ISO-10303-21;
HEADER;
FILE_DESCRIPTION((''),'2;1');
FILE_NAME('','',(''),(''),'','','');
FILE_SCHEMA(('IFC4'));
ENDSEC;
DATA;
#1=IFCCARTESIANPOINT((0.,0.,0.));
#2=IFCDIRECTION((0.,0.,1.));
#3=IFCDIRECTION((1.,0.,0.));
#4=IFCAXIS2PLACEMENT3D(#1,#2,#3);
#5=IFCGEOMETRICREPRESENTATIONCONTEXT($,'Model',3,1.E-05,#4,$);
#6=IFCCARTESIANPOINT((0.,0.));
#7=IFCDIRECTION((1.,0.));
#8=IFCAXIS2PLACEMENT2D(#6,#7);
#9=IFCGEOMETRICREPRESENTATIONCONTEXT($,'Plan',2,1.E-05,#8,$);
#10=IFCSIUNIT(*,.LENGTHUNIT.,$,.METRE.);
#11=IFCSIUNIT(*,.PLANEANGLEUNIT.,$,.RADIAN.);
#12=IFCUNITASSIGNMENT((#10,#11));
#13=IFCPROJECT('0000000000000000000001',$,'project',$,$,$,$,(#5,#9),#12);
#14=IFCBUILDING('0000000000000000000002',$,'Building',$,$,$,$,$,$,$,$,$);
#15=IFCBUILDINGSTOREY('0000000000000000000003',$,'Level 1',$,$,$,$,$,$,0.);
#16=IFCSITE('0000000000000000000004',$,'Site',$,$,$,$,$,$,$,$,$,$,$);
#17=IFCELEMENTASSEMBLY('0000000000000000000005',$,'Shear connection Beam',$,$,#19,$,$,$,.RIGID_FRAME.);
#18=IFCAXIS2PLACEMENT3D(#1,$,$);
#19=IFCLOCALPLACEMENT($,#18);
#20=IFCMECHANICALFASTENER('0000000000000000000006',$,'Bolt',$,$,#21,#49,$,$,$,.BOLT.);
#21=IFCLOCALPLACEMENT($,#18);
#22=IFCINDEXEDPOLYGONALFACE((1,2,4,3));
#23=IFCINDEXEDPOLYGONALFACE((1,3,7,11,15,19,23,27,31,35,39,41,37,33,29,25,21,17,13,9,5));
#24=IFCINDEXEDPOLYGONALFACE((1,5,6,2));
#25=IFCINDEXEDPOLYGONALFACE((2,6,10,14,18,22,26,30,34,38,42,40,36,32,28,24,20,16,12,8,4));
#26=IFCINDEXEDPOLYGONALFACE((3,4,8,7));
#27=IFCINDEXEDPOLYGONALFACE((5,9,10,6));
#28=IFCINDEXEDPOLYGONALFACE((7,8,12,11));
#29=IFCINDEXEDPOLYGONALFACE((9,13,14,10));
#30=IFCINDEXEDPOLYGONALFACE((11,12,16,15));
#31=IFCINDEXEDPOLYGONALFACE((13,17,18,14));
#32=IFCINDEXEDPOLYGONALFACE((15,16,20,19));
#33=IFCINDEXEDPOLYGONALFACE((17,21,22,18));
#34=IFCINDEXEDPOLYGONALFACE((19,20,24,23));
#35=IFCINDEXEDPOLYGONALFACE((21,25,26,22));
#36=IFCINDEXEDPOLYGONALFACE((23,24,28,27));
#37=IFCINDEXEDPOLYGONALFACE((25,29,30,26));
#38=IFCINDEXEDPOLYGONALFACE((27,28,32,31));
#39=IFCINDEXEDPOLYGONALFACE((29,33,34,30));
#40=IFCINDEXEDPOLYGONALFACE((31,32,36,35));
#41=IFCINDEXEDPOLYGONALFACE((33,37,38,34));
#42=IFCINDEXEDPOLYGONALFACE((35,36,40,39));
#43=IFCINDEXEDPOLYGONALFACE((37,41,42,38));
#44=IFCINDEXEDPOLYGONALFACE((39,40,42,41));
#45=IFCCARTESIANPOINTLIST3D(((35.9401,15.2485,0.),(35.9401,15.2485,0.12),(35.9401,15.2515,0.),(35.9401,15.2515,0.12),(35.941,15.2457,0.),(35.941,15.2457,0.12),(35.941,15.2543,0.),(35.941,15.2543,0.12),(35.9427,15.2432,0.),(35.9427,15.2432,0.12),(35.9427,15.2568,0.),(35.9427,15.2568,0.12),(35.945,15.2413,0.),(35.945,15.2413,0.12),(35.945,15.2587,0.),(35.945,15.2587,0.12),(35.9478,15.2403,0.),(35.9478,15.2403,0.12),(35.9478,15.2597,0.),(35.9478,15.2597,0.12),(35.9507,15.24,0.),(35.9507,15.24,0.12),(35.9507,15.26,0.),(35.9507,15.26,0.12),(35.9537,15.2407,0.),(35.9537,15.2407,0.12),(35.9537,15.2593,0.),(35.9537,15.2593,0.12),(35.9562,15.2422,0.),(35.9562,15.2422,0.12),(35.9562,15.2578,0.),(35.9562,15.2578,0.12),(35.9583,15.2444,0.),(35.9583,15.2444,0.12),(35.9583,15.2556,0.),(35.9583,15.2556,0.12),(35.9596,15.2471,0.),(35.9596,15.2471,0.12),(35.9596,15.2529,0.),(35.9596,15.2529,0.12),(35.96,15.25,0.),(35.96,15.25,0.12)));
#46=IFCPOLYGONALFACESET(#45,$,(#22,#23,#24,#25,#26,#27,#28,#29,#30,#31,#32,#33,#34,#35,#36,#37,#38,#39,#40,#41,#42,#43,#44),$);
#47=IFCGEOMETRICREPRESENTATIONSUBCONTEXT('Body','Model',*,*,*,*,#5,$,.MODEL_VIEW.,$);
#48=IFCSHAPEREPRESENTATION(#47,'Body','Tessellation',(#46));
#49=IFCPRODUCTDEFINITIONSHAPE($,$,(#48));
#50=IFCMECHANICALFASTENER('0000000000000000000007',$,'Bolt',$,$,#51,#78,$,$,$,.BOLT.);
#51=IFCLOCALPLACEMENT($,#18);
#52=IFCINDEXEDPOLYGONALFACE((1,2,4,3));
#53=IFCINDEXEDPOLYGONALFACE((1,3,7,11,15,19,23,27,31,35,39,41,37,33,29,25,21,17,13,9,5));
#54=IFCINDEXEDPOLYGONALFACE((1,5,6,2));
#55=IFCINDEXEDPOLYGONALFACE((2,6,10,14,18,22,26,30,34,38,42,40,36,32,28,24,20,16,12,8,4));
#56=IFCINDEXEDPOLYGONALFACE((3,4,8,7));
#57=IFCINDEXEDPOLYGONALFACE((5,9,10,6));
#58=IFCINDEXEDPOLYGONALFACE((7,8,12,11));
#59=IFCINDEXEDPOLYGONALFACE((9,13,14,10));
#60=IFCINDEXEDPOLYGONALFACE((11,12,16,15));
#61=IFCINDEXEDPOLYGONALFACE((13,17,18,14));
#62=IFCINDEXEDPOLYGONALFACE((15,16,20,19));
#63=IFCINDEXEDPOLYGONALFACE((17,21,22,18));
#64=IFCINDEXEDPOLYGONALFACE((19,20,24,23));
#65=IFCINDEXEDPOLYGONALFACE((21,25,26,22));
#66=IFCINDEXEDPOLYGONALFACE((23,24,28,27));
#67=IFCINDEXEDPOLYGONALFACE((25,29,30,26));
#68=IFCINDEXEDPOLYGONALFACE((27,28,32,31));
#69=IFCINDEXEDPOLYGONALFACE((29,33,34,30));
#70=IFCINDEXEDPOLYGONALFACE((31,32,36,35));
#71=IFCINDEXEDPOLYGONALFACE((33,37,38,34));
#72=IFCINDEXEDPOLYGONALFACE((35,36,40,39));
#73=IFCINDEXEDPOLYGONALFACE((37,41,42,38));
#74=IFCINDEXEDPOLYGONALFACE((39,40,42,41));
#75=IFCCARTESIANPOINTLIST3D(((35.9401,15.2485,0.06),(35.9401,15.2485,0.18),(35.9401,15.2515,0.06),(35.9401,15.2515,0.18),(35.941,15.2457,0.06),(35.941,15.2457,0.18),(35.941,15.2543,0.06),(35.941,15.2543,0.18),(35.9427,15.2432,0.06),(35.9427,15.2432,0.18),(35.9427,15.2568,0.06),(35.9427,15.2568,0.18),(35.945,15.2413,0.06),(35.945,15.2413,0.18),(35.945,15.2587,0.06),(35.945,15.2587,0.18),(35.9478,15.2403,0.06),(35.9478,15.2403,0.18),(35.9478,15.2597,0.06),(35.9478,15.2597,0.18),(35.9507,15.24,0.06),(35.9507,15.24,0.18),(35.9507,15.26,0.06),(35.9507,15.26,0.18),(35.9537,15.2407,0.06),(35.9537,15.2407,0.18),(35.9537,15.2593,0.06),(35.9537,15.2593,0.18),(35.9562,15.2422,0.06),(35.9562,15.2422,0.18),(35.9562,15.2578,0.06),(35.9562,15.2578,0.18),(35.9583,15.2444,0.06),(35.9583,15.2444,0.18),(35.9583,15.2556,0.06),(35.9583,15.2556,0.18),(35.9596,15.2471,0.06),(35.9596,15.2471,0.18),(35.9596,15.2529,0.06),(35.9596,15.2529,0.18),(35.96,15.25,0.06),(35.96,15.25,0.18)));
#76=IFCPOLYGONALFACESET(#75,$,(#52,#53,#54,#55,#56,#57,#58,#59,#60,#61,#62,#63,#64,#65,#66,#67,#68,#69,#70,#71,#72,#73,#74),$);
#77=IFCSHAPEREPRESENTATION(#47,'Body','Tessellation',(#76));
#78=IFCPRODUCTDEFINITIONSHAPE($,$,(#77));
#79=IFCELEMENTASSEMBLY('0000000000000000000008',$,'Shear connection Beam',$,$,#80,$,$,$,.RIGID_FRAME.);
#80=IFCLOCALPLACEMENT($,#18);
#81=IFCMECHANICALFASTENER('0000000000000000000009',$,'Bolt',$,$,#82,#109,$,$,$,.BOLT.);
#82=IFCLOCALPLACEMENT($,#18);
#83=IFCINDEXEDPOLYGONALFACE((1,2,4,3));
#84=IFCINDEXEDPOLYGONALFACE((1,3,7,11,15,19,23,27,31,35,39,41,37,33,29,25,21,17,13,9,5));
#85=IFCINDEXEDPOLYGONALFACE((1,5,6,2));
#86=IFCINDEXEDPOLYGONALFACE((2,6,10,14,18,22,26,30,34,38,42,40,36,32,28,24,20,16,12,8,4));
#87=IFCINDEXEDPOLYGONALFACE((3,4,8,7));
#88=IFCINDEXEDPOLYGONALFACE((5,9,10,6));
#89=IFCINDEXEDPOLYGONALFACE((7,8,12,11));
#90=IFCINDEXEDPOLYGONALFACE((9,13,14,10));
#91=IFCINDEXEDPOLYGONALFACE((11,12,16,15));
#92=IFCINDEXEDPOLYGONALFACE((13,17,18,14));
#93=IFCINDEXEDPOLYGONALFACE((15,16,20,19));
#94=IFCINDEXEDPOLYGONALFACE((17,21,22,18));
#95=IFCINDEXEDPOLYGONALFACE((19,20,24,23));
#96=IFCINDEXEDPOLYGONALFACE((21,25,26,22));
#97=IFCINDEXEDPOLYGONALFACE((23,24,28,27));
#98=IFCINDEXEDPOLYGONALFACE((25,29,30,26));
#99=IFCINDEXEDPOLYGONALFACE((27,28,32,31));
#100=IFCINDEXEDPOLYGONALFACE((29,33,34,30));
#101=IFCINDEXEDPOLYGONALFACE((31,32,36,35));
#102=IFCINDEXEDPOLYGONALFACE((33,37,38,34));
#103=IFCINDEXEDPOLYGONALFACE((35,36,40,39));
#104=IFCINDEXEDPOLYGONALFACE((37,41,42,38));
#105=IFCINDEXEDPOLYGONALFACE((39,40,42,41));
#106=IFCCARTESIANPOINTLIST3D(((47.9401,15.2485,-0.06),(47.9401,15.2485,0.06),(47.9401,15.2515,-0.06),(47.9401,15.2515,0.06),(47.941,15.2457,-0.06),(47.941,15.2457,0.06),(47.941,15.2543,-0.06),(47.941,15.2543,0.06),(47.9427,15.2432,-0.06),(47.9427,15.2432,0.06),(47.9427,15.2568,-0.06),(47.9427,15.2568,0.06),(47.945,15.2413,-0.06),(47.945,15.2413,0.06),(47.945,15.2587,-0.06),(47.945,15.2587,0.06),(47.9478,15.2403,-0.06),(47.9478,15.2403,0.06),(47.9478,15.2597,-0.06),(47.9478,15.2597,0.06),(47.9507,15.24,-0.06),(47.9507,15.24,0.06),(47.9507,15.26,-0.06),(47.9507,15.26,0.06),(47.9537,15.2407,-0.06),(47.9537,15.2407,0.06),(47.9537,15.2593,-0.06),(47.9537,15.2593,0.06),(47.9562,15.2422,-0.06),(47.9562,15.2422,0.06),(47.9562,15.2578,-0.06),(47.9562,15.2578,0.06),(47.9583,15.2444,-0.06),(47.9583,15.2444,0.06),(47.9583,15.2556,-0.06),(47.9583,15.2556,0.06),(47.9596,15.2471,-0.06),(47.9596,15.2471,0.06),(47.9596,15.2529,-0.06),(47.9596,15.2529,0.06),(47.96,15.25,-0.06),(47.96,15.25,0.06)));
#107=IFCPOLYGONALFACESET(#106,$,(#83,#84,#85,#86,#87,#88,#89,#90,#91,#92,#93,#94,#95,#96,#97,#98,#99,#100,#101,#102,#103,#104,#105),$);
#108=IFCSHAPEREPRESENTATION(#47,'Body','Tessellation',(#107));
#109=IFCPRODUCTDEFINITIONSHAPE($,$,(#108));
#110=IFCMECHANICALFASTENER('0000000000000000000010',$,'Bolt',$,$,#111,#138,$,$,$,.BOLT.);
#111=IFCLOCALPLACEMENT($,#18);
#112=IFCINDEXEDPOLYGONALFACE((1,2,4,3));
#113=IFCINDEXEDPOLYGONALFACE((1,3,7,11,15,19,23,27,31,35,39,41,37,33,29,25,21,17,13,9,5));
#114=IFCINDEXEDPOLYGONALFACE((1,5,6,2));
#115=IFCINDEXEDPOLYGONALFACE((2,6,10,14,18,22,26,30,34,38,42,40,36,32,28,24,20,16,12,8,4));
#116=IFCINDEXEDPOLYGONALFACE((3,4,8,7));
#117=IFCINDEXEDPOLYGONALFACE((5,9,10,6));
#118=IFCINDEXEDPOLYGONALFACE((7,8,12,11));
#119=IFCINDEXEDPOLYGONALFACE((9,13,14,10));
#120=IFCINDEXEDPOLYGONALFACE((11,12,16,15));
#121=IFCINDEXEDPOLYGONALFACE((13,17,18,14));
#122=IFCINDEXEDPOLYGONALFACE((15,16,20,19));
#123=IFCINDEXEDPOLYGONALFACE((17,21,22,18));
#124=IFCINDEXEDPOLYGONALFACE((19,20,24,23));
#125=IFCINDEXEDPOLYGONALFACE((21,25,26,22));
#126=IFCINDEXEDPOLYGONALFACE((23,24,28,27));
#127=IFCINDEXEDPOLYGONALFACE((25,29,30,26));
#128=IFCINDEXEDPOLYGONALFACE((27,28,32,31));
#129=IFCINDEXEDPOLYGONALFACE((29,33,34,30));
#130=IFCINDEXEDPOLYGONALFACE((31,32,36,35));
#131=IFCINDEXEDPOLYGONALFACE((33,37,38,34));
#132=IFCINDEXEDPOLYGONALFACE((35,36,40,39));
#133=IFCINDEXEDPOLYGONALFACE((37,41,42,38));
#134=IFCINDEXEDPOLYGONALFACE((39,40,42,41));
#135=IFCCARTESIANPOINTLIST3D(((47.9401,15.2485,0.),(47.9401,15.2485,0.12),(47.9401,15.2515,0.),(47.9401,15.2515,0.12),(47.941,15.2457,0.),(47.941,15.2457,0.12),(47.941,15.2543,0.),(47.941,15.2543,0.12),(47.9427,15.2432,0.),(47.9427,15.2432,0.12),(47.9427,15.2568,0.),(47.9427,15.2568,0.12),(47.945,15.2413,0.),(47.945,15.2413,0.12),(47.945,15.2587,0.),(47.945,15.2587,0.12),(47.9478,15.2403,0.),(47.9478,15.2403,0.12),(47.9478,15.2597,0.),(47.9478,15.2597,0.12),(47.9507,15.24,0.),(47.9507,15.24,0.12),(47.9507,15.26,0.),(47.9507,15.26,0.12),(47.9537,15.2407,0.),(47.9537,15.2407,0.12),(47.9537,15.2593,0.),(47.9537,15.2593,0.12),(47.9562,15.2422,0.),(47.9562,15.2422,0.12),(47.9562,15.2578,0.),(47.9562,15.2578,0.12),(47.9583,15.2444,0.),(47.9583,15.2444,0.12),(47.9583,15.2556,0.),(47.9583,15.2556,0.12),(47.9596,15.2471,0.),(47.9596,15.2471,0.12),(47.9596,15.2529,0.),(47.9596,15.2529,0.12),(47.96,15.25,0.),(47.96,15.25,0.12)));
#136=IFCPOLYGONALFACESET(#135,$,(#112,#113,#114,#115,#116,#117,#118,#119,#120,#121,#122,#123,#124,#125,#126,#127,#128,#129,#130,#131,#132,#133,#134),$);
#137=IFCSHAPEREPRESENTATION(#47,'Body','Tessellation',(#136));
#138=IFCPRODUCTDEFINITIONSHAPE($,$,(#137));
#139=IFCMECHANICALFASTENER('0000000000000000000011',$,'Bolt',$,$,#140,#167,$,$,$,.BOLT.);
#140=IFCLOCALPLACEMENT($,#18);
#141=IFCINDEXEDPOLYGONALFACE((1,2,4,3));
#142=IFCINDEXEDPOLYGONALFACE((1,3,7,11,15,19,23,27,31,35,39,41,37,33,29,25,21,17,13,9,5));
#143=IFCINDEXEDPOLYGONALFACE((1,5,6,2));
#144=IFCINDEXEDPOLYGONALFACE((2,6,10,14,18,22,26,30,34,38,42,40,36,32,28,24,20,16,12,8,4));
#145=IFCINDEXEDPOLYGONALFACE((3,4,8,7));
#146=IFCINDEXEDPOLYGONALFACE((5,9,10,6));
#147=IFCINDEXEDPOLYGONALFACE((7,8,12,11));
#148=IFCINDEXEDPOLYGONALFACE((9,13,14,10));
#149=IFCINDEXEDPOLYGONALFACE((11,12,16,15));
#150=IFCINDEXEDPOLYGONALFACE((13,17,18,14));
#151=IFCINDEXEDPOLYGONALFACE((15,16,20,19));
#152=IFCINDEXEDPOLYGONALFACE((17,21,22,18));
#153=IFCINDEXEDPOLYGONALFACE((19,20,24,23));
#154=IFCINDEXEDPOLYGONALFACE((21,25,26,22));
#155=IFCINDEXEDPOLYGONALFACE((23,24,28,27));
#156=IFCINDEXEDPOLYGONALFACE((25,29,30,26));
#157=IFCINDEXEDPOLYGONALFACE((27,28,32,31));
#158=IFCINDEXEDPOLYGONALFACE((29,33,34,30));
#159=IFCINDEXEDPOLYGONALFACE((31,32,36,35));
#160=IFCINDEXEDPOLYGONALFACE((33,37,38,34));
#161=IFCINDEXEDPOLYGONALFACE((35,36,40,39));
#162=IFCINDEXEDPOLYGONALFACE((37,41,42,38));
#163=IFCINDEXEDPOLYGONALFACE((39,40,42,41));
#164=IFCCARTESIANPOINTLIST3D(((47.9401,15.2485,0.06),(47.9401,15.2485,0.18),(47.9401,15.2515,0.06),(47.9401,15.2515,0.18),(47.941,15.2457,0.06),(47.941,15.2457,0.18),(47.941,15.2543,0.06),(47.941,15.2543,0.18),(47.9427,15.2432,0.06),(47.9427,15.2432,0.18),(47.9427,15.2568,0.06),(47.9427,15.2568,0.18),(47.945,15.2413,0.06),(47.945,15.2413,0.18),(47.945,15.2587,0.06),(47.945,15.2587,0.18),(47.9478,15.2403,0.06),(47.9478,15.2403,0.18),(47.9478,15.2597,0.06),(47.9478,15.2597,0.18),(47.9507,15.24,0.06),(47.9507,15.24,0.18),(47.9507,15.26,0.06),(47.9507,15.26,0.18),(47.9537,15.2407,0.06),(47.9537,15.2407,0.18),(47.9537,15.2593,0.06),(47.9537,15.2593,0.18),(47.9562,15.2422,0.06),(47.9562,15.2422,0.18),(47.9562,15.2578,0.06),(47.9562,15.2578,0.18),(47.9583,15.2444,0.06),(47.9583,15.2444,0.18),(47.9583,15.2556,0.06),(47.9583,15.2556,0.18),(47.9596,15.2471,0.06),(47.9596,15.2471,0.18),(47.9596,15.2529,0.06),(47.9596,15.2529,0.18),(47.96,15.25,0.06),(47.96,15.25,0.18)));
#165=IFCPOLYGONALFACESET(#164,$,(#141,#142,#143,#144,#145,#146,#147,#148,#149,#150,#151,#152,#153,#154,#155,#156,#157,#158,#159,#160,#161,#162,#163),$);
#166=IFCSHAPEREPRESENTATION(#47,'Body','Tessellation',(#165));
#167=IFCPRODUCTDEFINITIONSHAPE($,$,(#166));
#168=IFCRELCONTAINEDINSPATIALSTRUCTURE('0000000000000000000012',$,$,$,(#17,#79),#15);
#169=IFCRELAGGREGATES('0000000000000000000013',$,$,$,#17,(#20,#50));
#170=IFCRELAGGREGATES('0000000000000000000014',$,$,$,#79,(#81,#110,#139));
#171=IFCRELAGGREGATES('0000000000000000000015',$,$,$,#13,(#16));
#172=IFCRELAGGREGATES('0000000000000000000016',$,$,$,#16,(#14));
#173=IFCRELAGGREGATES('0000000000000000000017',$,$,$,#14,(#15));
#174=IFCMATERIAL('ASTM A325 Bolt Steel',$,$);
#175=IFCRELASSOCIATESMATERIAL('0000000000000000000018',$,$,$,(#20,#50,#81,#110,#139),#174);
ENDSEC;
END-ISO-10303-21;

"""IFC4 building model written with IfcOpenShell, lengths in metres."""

from ifc_helpers import new_model, si_unit, frame, origin_with_axes, origin_2d, origin_2d_with_axis, place, context, subcontext, project, spatial, circle, extrude, material, element, aggregate, save


model = new_model("IFC4")

# Units and contexts
model_context = context("Model", 3, precision=1e-05, world=origin_with_axes())
plan_context = context("Plan", 2, precision=1e-05, world=origin_2d_with_axis())
body_context = subcontext(model_context, "Body", "Model", "MODEL_VIEW")
ifc_project = project(units=[si_unit("LENGTHUNIT", "METRE"), si_unit("PLANEANGLEUNIT", "RADIAN")], contexts=[model_context, plan_context])

# Site, building, storey
site = spatial("IfcSite", under=ifc_project, Name="Site")
building = spatial("IfcBuilding", under=site, Name="Building")
storey = spatial("IfcBuildingStorey", under=building, Name="Level 1", Elevation=0.0)

# Element assembly
assembly_1 = element("IfcElementAssembly", 1, inside=storey, Name="Shear connection Beam", PredefinedType="RIGID_FRAME")

# Shared definitions
ifc_material_1 = material(Name="ASTM A325 Bolt Steel")

# Mechanical fasteners
mechanical_fastener_1_placement = place(None, frame((35.95, 15.25, 0.0), z_axis=(0.0, 0.0, 1.0), x_axis=(1.0, 0.0, 0.0)))
mechanical_fastener_1 = element("IfcMechanicalFastener", 2, at=mechanical_fastener_1_placement, material=ifc_material_1, Name="Bolt", PredefinedType="BOLT", context=body_context, shape_type="SweptSolid", body=[
    extrude(circle(Radius=0.01, at=origin_2d()), origin_with_axes(), (0.0, 0.0, 1.0), 0.12),
])
mechanical_fastener_2_placement = place(None, frame((35.95, 15.25, 0.06), z_axis=(0.0, 0.0, 1.0), x_axis=(1.0, 0.0, 0.0)))
mechanical_fastener_2 = element("IfcMechanicalFastener", 3, at=mechanical_fastener_2_placement, material=ifc_material_1, Name="Bolt", PredefinedType="BOLT", context=body_context, shape_type="SweptSolid", body=[
    extrude(circle(Radius=0.01, at=origin_2d()), origin_with_axes(), (0.0, 0.0, 1.0), 0.12),
])
aggregate(assembly_1, [mechanical_fastener_1, mechanical_fastener_2])

# Element assembly, mechanical fasteners
assembly_2 = element("IfcElementAssembly", 4, inside=storey, Name="Shear connection Beam", PredefinedType="RIGID_FRAME")
mechanical_fastener_3_placement = place(None, frame((47.95, 15.25, -0.06), z_axis=(0.0, 0.0, 1.0), x_axis=(1.0, 0.0, 0.0)))
mechanical_fastener_3 = element("IfcMechanicalFastener", 5, at=mechanical_fastener_3_placement, material=ifc_material_1, Name="Bolt", PredefinedType="BOLT", context=body_context, shape_type="SweptSolid", body=[
    extrude(circle(Radius=0.01, at=origin_2d()), origin_with_axes(), (0.0, 0.0, 1.0), 0.12),
])
mechanical_fastener_4_placement = place(None, frame((47.95, 15.25, 0.0), z_axis=(0.0, 0.0, 1.0), x_axis=(1.0, 0.0, 0.0)))
mechanical_fastener_4 = element("IfcMechanicalFastener", 6, at=mechanical_fastener_4_placement, material=ifc_material_1, Name="Bolt", PredefinedType="BOLT", context=body_context, shape_type="SweptSolid", body=[
    extrude(circle(Radius=0.01, at=origin_2d()), origin_with_axes(), (0.0, 0.0, 1.0), 0.12),
])
mechanical_fastener_5_placement = place(None, frame((47.95, 15.25, 0.06), z_axis=(0.0, 0.0, 1.0), x_axis=(1.0, 0.0, 0.0)))
mechanical_fastener_5 = element("IfcMechanicalFastener", 7, at=mechanical_fastener_5_placement, material=ifc_material_1, Name="Bolt", PredefinedType="BOLT", context=body_context, shape_type="SweptSolid", body=[
    extrude(circle(Radius=0.01, at=origin_2d()), origin_with_axes(), (0.0, 0.0, 1.0), 0.12),
])
aggregate(assembly_2, [mechanical_fastener_3, mechanical_fastener_4, mechanical_fastener_5])

save(model, "model.ifc")
